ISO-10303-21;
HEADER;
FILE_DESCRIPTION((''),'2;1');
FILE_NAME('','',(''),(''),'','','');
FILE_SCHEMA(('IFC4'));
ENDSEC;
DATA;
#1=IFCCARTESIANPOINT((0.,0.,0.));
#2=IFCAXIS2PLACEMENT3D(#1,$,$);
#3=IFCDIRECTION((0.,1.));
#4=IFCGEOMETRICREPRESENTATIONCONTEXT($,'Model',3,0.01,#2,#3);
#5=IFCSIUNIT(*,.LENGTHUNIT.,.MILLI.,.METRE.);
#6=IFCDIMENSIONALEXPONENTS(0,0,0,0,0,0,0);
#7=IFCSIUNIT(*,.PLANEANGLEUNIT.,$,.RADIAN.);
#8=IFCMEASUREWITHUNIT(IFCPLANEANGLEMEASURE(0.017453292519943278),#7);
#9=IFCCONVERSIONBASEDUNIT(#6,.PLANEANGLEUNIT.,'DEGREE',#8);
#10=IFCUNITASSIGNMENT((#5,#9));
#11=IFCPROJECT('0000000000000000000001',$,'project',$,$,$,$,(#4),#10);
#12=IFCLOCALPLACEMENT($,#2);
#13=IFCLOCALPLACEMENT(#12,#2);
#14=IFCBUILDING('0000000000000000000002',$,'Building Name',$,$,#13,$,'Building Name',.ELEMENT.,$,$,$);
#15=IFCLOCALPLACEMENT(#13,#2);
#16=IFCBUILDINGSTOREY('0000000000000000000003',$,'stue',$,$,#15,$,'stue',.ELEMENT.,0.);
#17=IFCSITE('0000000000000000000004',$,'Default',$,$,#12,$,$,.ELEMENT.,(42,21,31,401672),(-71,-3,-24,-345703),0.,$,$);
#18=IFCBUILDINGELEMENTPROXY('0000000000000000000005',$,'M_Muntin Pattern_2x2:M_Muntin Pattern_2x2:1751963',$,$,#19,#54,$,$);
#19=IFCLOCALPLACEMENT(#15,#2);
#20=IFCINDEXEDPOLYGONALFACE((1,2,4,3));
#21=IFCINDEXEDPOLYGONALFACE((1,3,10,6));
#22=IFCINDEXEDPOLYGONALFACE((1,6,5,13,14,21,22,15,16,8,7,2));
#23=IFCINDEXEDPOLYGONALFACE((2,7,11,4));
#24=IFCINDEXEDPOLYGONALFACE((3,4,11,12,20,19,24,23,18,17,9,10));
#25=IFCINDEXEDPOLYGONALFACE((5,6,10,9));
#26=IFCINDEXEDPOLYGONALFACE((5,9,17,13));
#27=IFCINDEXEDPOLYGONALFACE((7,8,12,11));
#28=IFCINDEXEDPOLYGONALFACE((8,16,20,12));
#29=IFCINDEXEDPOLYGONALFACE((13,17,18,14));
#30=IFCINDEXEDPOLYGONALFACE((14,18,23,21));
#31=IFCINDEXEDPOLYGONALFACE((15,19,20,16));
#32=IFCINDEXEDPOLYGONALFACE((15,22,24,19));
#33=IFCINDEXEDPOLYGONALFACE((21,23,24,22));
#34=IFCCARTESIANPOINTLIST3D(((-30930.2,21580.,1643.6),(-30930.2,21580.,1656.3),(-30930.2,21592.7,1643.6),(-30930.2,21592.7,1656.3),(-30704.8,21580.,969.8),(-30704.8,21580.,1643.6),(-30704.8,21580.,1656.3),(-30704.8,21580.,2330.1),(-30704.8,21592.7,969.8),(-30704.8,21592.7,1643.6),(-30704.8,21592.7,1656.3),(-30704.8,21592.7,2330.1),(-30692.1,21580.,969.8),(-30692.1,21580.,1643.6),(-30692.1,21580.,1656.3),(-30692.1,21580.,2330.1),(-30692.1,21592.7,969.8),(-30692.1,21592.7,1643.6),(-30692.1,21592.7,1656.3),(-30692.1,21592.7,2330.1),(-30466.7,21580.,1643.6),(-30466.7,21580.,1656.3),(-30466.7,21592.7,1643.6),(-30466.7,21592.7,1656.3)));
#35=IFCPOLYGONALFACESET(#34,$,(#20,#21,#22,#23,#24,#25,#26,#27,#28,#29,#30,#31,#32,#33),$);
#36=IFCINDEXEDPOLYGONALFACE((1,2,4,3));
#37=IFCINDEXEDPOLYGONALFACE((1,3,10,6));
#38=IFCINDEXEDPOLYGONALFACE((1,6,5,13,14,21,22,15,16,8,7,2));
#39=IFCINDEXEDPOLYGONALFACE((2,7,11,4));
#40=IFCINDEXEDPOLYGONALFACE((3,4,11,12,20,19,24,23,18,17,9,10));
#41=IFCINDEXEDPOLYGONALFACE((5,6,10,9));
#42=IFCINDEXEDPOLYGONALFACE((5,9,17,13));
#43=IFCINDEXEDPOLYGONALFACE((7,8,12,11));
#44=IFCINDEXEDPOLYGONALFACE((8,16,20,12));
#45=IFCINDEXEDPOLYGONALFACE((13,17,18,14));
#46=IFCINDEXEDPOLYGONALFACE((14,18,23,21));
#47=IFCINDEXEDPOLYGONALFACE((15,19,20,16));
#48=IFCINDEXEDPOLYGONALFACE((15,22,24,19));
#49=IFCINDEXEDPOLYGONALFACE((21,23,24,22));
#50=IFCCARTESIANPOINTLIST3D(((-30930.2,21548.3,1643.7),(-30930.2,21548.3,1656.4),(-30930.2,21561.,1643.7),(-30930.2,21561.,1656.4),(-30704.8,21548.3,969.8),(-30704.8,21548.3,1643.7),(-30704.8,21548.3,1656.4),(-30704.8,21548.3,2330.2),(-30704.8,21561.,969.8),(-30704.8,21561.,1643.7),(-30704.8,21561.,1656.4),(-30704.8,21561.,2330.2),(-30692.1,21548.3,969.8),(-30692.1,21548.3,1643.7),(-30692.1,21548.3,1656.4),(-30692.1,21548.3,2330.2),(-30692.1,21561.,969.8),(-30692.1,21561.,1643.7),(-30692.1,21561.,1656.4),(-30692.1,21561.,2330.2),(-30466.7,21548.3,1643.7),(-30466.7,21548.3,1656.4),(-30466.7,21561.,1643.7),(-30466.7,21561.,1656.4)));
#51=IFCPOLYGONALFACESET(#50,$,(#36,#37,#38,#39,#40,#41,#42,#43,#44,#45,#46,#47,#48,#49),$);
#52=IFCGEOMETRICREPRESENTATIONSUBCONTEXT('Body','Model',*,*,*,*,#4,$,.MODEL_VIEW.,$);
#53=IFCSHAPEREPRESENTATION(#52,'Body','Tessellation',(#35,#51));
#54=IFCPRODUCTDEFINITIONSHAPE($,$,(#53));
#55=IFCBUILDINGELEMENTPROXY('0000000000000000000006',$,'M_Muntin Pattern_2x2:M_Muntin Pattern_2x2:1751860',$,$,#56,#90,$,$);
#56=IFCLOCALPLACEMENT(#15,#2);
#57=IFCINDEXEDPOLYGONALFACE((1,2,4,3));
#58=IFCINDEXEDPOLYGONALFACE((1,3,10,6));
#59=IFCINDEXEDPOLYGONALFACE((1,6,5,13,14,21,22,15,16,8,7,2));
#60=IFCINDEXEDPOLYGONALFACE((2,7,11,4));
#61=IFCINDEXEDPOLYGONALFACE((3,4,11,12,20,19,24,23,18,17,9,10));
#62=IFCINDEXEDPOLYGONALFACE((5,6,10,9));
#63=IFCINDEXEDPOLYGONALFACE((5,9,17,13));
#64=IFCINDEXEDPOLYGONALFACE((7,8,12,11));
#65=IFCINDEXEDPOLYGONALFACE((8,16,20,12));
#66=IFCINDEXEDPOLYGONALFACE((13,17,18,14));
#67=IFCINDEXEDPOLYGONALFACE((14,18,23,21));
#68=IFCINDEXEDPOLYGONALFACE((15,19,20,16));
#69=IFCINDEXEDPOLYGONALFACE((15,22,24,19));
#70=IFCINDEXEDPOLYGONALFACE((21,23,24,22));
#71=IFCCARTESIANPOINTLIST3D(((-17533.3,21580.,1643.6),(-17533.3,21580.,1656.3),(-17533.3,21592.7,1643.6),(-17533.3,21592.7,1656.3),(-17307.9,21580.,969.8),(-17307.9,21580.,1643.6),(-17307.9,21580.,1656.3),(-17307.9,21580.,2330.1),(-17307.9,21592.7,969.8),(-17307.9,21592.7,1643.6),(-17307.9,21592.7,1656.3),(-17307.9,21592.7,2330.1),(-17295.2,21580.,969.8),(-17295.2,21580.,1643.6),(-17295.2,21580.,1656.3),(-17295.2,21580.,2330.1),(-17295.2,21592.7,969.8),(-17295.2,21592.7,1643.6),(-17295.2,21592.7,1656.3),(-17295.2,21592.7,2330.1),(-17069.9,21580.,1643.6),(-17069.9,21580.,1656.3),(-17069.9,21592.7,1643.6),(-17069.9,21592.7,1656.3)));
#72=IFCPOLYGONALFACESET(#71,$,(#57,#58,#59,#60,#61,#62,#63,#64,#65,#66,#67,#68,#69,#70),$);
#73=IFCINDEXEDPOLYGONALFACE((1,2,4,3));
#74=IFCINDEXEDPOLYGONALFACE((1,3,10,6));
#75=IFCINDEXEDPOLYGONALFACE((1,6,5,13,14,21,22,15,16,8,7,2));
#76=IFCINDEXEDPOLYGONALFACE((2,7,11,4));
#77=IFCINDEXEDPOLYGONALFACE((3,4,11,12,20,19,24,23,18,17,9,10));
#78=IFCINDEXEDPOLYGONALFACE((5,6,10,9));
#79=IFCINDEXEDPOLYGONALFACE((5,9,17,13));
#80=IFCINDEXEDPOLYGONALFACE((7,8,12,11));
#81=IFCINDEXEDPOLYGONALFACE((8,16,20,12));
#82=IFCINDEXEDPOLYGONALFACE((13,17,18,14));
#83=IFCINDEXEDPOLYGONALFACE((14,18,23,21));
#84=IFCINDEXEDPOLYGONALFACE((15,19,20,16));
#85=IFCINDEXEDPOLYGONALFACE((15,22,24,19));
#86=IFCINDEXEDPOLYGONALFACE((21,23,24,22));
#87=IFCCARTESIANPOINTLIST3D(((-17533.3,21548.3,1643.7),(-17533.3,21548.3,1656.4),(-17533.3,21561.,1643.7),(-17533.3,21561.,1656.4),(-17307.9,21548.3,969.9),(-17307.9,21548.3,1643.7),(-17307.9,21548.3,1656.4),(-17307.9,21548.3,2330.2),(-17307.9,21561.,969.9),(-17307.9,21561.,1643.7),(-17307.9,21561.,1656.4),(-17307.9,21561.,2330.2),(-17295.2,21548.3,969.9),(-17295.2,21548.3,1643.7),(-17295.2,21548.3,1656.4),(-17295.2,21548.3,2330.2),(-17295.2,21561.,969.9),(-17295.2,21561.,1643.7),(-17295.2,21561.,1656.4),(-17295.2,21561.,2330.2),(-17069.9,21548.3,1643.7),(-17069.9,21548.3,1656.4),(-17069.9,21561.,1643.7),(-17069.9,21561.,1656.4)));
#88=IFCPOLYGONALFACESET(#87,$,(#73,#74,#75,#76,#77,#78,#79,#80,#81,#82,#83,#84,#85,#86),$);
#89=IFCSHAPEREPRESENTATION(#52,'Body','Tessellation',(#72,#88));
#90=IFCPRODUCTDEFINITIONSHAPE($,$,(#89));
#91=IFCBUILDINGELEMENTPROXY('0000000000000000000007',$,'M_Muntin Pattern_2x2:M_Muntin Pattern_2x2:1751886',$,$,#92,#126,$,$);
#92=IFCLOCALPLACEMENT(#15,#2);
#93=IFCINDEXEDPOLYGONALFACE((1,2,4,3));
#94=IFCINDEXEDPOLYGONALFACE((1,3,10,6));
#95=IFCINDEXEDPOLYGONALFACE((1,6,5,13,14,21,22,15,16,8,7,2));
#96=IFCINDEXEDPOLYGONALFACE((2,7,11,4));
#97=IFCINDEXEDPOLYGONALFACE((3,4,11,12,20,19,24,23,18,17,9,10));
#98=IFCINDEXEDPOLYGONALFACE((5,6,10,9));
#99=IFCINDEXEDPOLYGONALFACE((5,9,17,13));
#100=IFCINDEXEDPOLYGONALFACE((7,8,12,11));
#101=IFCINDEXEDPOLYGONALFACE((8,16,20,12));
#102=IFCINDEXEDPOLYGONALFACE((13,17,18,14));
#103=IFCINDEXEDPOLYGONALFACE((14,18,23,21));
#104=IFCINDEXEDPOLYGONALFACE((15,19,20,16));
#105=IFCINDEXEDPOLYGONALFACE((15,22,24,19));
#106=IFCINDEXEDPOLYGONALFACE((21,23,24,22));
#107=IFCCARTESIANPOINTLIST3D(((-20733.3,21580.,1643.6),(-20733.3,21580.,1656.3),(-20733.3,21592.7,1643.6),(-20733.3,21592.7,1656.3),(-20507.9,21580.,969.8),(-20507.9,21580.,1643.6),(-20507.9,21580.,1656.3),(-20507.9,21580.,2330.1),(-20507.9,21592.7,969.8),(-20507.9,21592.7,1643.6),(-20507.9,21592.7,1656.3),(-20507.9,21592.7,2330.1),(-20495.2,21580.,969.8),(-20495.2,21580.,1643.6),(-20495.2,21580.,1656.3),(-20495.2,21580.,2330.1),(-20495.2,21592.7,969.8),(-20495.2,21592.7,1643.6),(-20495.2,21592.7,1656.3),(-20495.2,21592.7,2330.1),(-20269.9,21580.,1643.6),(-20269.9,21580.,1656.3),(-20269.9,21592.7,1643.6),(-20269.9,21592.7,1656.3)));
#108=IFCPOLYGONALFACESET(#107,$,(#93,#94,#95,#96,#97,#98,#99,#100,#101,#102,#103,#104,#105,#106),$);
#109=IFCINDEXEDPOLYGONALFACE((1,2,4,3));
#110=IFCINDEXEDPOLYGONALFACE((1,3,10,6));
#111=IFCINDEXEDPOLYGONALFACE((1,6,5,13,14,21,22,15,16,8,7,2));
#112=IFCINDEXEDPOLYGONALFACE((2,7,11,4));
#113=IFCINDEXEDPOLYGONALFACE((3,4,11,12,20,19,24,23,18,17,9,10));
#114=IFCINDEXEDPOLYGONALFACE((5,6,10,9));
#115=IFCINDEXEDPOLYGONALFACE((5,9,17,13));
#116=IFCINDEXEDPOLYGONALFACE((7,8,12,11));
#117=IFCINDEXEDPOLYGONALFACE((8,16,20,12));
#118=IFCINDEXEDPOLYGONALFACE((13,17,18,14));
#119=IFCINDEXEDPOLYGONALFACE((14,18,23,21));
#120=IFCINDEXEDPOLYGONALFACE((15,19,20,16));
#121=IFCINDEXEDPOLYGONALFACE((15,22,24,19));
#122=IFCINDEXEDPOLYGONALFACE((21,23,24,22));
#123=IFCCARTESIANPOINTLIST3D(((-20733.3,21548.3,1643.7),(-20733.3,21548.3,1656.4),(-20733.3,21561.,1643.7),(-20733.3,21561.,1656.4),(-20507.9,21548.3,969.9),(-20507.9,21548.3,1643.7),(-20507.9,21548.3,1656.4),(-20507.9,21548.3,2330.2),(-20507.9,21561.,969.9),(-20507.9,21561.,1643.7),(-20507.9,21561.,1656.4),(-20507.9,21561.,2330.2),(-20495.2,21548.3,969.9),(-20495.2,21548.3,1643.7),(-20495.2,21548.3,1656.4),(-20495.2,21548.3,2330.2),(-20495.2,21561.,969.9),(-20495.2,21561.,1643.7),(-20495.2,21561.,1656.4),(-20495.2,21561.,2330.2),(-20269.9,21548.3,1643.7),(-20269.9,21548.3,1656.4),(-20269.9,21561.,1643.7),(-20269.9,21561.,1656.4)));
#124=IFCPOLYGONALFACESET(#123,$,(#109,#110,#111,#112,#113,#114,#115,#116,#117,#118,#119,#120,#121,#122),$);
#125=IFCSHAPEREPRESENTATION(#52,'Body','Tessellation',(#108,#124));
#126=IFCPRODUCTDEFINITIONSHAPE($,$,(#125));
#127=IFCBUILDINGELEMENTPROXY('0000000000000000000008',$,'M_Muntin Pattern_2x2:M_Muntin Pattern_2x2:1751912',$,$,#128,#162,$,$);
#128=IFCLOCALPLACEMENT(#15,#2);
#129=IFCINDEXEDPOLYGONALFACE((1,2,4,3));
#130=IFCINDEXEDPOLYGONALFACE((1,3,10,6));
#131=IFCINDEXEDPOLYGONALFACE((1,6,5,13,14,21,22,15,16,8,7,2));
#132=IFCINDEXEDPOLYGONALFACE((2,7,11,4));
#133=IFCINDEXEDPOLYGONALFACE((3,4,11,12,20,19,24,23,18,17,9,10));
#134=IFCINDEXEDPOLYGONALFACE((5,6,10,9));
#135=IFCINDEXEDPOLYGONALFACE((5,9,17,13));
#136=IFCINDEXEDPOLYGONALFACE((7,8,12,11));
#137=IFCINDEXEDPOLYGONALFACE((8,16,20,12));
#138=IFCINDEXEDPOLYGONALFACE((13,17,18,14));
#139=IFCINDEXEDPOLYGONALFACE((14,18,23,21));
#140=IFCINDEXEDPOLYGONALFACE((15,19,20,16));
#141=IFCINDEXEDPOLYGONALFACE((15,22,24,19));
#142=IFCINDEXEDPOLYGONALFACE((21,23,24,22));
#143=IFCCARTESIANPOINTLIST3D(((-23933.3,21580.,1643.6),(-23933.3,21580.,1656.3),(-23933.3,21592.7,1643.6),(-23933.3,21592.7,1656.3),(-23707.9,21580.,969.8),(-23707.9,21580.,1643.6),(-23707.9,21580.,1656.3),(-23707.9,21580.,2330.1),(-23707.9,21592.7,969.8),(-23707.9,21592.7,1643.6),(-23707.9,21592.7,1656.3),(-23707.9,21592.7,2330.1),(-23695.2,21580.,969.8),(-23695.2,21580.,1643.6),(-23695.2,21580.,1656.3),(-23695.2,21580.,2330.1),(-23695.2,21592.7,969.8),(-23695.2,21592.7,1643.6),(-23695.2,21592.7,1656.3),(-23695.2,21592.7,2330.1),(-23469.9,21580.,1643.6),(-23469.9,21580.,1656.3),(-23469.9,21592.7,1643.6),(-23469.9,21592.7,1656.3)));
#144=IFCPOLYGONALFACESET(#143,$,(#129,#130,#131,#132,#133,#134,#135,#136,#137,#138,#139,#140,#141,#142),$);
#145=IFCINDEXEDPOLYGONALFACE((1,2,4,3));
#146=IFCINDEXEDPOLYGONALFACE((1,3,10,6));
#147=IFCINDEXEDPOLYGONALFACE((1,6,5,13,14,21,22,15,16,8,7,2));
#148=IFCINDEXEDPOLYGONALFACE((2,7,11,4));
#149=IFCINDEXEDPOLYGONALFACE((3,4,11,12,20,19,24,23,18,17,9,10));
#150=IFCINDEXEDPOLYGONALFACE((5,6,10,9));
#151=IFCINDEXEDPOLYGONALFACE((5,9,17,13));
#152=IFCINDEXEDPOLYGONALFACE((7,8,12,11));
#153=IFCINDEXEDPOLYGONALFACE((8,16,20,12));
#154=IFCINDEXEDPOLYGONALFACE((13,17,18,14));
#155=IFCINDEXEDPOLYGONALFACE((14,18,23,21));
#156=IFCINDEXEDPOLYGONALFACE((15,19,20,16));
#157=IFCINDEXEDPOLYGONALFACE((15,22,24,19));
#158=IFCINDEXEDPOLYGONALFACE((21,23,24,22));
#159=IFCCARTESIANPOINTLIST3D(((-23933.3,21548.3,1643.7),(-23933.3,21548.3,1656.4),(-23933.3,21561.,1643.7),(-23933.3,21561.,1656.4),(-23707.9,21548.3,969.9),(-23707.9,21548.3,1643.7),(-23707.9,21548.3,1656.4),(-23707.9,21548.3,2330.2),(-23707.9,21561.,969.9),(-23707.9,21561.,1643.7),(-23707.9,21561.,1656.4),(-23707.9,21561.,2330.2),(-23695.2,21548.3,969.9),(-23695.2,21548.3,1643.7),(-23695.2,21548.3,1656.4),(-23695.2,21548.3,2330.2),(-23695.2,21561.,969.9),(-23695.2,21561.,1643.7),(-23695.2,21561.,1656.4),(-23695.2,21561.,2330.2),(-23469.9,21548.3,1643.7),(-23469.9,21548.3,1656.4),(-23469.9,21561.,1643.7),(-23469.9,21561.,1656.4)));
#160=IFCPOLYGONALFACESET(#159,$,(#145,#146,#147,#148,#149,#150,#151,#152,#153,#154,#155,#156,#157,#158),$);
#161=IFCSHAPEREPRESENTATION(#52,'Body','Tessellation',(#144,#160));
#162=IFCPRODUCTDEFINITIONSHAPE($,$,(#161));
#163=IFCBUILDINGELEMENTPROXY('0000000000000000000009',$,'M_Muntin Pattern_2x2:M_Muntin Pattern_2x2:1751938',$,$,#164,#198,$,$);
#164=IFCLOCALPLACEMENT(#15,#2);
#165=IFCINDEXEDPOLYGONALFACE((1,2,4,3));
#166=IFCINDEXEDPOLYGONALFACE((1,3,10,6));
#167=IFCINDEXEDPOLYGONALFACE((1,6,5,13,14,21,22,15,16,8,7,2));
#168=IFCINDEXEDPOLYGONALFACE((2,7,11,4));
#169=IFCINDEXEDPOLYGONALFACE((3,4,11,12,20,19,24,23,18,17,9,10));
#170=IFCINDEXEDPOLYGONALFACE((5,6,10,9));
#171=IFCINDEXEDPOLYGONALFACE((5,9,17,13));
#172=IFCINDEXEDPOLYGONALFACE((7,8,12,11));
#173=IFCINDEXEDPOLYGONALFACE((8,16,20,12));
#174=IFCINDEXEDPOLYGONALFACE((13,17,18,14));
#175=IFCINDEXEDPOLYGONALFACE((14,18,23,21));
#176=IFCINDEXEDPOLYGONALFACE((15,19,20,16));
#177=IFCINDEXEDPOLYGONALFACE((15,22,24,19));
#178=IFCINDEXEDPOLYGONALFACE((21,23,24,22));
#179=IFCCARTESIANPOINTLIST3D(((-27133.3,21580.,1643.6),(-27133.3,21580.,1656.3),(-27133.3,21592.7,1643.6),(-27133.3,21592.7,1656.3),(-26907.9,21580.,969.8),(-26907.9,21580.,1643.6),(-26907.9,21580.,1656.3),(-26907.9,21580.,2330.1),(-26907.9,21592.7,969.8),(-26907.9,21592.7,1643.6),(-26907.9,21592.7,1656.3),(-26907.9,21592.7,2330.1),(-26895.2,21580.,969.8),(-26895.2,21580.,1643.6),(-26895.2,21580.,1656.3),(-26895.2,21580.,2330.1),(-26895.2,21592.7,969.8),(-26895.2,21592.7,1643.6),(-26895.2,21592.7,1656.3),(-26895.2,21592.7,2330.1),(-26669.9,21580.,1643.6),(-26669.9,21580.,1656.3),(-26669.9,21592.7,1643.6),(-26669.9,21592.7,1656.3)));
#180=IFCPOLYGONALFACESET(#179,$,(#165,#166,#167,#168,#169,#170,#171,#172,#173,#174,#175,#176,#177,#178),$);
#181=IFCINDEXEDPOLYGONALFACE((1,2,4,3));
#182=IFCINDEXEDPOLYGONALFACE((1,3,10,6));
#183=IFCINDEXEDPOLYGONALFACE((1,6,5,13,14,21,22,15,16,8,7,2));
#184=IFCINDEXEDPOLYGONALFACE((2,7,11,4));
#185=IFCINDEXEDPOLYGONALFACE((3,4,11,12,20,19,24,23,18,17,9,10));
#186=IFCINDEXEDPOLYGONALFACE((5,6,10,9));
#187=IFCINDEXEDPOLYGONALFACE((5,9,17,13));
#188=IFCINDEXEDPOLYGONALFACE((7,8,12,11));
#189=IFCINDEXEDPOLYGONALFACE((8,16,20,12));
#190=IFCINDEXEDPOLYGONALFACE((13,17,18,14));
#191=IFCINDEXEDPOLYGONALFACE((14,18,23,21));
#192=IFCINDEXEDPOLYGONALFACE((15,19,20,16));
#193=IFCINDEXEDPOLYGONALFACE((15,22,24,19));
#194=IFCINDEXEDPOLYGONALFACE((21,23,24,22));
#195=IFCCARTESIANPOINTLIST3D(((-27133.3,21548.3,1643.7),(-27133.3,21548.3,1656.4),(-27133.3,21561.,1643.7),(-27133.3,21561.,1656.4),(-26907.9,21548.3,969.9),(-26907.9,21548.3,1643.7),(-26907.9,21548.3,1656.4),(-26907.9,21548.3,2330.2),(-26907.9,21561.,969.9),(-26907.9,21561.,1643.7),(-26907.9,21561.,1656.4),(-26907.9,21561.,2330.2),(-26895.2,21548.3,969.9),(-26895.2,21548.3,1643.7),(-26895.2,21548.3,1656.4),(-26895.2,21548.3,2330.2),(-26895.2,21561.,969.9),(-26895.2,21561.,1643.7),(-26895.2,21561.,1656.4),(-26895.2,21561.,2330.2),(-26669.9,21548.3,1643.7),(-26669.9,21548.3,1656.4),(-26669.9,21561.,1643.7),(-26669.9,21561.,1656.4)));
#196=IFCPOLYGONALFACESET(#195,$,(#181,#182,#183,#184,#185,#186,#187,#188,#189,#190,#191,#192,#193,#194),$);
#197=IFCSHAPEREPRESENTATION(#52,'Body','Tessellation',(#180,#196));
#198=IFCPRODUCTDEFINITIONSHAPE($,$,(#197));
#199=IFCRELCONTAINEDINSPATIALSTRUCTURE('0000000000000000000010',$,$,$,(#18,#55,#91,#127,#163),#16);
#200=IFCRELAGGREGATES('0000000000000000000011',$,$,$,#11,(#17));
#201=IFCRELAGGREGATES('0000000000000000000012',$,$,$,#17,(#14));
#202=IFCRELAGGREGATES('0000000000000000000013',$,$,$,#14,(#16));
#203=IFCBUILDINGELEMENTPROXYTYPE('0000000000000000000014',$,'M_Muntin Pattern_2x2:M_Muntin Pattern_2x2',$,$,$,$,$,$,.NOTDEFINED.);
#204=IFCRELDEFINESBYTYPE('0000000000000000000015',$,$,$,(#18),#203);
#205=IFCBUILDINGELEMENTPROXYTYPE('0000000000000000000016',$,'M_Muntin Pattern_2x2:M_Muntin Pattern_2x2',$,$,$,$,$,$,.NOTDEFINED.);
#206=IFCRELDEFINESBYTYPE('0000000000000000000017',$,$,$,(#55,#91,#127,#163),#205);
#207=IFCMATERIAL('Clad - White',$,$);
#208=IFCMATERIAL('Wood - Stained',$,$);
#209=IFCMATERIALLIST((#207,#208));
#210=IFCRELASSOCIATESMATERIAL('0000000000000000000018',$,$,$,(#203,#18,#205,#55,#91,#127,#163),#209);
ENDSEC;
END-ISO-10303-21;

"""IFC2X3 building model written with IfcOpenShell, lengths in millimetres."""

from ifc_helpers import new_model, entity, si_unit, converted_unit, direction, frame, origin, place, context, subcontext, project, spatial, polyline, outline, extrude, source, transform, mapped, material, material_list, type_object, type_shapes, element, save


model = new_model("IFC2X3")

# Units and contexts
model_context = context("Model", 3, precision=0.01, world=origin(), true_north=direction((0.0, 1.0)))
body_context = subcontext(model_context, "Body", "Model", "MODEL_VIEW")
ifc_project = project(units=[si_unit("LENGTHUNIT", "METRE", prefix="MILLI"), converted_unit("PLANEANGLEUNIT", "DEGREE", entity("IfcPlaneAngleMeasure", 0.017453292519943278), si_unit("PLANEANGLEUNIT", "RADIAN"), dimensions=[0, 0, 0, 0, 0, 0, 0])], contexts=[model_context])

# Site, building, storey
site_placement = place(None, origin())
site = spatial("IfcSite", under=ifc_project, at=site_placement, Name="Default", CompositionType="ELEMENT", RefLatitude=(42, 21, 31, 401672), RefLongitude=(-71, -3, -24, -345703), RefElevation=0.0)
building_placement = place(site_placement, origin())
building = spatial("IfcBuilding", under=site, at=building_placement, Name="Building Name", LongName="Building Name", CompositionType="ELEMENT")
storey_placement = place(building_placement, origin())
storey = spatial("IfcBuildingStorey", under=building, at=storey_placement, Name="stue", LongName="stue", CompositionType="ELEMENT", Elevation=0.0)

# Building element proxies
ifc_material_1 = material(Name="Clad - White")
ifc_material_2 = material(Name="Wood - Stained")
ifc_material_list = material_list([ifc_material_1, ifc_material_2])
building_element_proxy_type_1 = type_object("IfcBuildingElementProxyType", Name="M_Muntin Pattern_2x2:M_Muntin Pattern_2x2", PredefinedType="NOTDEFINED", material=ifc_material_list)
shared_shape_1 = source(origin(), body_context, "Body", "SweptSolid", [
    extrude(outline(polyline([(6.4, -6.4), (680.1, -6.4), (680.1, 6.3), (6.4, 6.3), (6.4, 231.7), (-6.3, 231.7), (-6.3, 6.3), (-680.2, 6.3), (-680.2, -6.4), (-6.3, -6.4), (-6.3, -231.7), (6.4, -231.7), (6.4, -6.4)])), frame((0.0, 9.5, 680.1), z_axis=(0.0, 1.0, 0.0), x_axis=(0.0, 0.0, 1.0)), (0.0, 0.0, 1.0), 12.7),
    extrude(outline(polyline([(6.4, -6.4), (680.2, -6.4), (680.2, 6.3), (6.4, 6.3), (6.4, 231.7), (-6.3, 231.7), (-6.3, 6.3), (-680.2, 6.3), (-680.2, -6.4), (-6.3, -6.4), (-6.3, -231.7), (6.4, -231.7), (6.4, -6.4)])), frame((0.0, -22.2, 680.2), z_axis=(0.0, 1.0, 0.0), x_axis=(0.0, 0.0, 1.0)), (0.0, 0.0, 1.0), 12.7),
])
type_shapes(building_element_proxy_type_1, [shared_shape_1])
for number, where, name in (
    (1, (-30698.4, 21570.5, 969.8), "M_Muntin Pattern_2x2:M_Muntin Pattern_2x2:1751963"),
):
    element("IfcBuildingElementProxy", number, at=place(storey_placement, frame(where)), inside=storey, type_object=building_element_proxy_type_1, material=ifc_material_list, Name=name, context=body_context, shape_type="MappedRepresentation", body=[
        mapped(shared_shape_1, transform((0.0, 0.0, 0.0), scale=1.0)),
    ])
building_element_proxy_type_2 = type_object("IfcBuildingElementProxyType", Name="M_Muntin Pattern_2x2:M_Muntin Pattern_2x2", PredefinedType="NOTDEFINED", material=ifc_material_list)
shared_shape_2 = source(origin(), body_context, "Body", "SweptSolid", [
    extrude(outline(polyline([(6.4, -6.4), (680.1, -6.4), (680.1, 6.3), (6.4, 6.3), (6.4, 231.7), (-6.3, 231.7), (-6.3, 6.3), (-680.2, 6.3), (-680.2, -6.4), (-6.3, -6.4), (-6.3, -231.7), (6.4, -231.7), (6.4, -6.4)])), frame((0.0, -22.2, 680.1), z_axis=(0.0, 1.0, 0.0), x_axis=(0.0, 0.0, 1.0)), (0.0, 0.0, 1.0), 12.7),
    extrude(outline(polyline([(6.4, -6.4), (680.2, -6.4), (680.2, 6.3), (6.4, 6.3), (6.4, 231.7), (-6.3, 231.7), (-6.3, 6.3), (-680.2, 6.3), (-680.2, -6.4), (-6.3, -6.4), (-6.3, -231.7), (6.4, -231.7), (6.4, -6.4)])), frame((0.0, 9.5, 680.2), z_axis=(0.0, 1.0, 0.0), x_axis=(0.0, 0.0, 1.0)), (0.0, 0.0, 1.0), 12.7),
])
type_shapes(building_element_proxy_type_2, [shared_shape_2])
for number, where, z_axis, x_axis, name in (
    (2, (-17301.6, 21570.5, 969.9), (0.0, 0.0, 1.0), (-1.0, 0.0, 0.0), "M_Muntin Pattern_2x2:M_Muntin Pattern_2x2:1751860"),
    (3, (-20501.6, 21570.5, 969.9), (0.0, 0.0, 1.0), (-1.0, 0.0, 0.0), "M_Muntin Pattern_2x2:M_Muntin Pattern_2x2:1751886"),
    (4, (-23701.6, 21570.5, 969.9), (0.0, 0.0, 1.0), (-1.0, 0.0, 0.0), "M_Muntin Pattern_2x2:M_Muntin Pattern_2x2:1751912"),
    (5, (-26901.6, 21570.5, 969.9), (0.0, 0.0, 1.0), (-1.0, 0.0, 0.0), "M_Muntin Pattern_2x2:M_Muntin Pattern_2x2:1751938"),
):
    element("IfcBuildingElementProxy", number, at=place(storey_placement, frame(where, z_axis=z_axis, x_axis=x_axis)), inside=storey, type_object=building_element_proxy_type_2, material=ifc_material_list, Name=name, context=body_context, shape_type="MappedRepresentation", body=[
        mapped(shared_shape_2, transform((0.0, 0.0, 0.0), scale=1.0)),
    ])

save(model, "model.ifc")
